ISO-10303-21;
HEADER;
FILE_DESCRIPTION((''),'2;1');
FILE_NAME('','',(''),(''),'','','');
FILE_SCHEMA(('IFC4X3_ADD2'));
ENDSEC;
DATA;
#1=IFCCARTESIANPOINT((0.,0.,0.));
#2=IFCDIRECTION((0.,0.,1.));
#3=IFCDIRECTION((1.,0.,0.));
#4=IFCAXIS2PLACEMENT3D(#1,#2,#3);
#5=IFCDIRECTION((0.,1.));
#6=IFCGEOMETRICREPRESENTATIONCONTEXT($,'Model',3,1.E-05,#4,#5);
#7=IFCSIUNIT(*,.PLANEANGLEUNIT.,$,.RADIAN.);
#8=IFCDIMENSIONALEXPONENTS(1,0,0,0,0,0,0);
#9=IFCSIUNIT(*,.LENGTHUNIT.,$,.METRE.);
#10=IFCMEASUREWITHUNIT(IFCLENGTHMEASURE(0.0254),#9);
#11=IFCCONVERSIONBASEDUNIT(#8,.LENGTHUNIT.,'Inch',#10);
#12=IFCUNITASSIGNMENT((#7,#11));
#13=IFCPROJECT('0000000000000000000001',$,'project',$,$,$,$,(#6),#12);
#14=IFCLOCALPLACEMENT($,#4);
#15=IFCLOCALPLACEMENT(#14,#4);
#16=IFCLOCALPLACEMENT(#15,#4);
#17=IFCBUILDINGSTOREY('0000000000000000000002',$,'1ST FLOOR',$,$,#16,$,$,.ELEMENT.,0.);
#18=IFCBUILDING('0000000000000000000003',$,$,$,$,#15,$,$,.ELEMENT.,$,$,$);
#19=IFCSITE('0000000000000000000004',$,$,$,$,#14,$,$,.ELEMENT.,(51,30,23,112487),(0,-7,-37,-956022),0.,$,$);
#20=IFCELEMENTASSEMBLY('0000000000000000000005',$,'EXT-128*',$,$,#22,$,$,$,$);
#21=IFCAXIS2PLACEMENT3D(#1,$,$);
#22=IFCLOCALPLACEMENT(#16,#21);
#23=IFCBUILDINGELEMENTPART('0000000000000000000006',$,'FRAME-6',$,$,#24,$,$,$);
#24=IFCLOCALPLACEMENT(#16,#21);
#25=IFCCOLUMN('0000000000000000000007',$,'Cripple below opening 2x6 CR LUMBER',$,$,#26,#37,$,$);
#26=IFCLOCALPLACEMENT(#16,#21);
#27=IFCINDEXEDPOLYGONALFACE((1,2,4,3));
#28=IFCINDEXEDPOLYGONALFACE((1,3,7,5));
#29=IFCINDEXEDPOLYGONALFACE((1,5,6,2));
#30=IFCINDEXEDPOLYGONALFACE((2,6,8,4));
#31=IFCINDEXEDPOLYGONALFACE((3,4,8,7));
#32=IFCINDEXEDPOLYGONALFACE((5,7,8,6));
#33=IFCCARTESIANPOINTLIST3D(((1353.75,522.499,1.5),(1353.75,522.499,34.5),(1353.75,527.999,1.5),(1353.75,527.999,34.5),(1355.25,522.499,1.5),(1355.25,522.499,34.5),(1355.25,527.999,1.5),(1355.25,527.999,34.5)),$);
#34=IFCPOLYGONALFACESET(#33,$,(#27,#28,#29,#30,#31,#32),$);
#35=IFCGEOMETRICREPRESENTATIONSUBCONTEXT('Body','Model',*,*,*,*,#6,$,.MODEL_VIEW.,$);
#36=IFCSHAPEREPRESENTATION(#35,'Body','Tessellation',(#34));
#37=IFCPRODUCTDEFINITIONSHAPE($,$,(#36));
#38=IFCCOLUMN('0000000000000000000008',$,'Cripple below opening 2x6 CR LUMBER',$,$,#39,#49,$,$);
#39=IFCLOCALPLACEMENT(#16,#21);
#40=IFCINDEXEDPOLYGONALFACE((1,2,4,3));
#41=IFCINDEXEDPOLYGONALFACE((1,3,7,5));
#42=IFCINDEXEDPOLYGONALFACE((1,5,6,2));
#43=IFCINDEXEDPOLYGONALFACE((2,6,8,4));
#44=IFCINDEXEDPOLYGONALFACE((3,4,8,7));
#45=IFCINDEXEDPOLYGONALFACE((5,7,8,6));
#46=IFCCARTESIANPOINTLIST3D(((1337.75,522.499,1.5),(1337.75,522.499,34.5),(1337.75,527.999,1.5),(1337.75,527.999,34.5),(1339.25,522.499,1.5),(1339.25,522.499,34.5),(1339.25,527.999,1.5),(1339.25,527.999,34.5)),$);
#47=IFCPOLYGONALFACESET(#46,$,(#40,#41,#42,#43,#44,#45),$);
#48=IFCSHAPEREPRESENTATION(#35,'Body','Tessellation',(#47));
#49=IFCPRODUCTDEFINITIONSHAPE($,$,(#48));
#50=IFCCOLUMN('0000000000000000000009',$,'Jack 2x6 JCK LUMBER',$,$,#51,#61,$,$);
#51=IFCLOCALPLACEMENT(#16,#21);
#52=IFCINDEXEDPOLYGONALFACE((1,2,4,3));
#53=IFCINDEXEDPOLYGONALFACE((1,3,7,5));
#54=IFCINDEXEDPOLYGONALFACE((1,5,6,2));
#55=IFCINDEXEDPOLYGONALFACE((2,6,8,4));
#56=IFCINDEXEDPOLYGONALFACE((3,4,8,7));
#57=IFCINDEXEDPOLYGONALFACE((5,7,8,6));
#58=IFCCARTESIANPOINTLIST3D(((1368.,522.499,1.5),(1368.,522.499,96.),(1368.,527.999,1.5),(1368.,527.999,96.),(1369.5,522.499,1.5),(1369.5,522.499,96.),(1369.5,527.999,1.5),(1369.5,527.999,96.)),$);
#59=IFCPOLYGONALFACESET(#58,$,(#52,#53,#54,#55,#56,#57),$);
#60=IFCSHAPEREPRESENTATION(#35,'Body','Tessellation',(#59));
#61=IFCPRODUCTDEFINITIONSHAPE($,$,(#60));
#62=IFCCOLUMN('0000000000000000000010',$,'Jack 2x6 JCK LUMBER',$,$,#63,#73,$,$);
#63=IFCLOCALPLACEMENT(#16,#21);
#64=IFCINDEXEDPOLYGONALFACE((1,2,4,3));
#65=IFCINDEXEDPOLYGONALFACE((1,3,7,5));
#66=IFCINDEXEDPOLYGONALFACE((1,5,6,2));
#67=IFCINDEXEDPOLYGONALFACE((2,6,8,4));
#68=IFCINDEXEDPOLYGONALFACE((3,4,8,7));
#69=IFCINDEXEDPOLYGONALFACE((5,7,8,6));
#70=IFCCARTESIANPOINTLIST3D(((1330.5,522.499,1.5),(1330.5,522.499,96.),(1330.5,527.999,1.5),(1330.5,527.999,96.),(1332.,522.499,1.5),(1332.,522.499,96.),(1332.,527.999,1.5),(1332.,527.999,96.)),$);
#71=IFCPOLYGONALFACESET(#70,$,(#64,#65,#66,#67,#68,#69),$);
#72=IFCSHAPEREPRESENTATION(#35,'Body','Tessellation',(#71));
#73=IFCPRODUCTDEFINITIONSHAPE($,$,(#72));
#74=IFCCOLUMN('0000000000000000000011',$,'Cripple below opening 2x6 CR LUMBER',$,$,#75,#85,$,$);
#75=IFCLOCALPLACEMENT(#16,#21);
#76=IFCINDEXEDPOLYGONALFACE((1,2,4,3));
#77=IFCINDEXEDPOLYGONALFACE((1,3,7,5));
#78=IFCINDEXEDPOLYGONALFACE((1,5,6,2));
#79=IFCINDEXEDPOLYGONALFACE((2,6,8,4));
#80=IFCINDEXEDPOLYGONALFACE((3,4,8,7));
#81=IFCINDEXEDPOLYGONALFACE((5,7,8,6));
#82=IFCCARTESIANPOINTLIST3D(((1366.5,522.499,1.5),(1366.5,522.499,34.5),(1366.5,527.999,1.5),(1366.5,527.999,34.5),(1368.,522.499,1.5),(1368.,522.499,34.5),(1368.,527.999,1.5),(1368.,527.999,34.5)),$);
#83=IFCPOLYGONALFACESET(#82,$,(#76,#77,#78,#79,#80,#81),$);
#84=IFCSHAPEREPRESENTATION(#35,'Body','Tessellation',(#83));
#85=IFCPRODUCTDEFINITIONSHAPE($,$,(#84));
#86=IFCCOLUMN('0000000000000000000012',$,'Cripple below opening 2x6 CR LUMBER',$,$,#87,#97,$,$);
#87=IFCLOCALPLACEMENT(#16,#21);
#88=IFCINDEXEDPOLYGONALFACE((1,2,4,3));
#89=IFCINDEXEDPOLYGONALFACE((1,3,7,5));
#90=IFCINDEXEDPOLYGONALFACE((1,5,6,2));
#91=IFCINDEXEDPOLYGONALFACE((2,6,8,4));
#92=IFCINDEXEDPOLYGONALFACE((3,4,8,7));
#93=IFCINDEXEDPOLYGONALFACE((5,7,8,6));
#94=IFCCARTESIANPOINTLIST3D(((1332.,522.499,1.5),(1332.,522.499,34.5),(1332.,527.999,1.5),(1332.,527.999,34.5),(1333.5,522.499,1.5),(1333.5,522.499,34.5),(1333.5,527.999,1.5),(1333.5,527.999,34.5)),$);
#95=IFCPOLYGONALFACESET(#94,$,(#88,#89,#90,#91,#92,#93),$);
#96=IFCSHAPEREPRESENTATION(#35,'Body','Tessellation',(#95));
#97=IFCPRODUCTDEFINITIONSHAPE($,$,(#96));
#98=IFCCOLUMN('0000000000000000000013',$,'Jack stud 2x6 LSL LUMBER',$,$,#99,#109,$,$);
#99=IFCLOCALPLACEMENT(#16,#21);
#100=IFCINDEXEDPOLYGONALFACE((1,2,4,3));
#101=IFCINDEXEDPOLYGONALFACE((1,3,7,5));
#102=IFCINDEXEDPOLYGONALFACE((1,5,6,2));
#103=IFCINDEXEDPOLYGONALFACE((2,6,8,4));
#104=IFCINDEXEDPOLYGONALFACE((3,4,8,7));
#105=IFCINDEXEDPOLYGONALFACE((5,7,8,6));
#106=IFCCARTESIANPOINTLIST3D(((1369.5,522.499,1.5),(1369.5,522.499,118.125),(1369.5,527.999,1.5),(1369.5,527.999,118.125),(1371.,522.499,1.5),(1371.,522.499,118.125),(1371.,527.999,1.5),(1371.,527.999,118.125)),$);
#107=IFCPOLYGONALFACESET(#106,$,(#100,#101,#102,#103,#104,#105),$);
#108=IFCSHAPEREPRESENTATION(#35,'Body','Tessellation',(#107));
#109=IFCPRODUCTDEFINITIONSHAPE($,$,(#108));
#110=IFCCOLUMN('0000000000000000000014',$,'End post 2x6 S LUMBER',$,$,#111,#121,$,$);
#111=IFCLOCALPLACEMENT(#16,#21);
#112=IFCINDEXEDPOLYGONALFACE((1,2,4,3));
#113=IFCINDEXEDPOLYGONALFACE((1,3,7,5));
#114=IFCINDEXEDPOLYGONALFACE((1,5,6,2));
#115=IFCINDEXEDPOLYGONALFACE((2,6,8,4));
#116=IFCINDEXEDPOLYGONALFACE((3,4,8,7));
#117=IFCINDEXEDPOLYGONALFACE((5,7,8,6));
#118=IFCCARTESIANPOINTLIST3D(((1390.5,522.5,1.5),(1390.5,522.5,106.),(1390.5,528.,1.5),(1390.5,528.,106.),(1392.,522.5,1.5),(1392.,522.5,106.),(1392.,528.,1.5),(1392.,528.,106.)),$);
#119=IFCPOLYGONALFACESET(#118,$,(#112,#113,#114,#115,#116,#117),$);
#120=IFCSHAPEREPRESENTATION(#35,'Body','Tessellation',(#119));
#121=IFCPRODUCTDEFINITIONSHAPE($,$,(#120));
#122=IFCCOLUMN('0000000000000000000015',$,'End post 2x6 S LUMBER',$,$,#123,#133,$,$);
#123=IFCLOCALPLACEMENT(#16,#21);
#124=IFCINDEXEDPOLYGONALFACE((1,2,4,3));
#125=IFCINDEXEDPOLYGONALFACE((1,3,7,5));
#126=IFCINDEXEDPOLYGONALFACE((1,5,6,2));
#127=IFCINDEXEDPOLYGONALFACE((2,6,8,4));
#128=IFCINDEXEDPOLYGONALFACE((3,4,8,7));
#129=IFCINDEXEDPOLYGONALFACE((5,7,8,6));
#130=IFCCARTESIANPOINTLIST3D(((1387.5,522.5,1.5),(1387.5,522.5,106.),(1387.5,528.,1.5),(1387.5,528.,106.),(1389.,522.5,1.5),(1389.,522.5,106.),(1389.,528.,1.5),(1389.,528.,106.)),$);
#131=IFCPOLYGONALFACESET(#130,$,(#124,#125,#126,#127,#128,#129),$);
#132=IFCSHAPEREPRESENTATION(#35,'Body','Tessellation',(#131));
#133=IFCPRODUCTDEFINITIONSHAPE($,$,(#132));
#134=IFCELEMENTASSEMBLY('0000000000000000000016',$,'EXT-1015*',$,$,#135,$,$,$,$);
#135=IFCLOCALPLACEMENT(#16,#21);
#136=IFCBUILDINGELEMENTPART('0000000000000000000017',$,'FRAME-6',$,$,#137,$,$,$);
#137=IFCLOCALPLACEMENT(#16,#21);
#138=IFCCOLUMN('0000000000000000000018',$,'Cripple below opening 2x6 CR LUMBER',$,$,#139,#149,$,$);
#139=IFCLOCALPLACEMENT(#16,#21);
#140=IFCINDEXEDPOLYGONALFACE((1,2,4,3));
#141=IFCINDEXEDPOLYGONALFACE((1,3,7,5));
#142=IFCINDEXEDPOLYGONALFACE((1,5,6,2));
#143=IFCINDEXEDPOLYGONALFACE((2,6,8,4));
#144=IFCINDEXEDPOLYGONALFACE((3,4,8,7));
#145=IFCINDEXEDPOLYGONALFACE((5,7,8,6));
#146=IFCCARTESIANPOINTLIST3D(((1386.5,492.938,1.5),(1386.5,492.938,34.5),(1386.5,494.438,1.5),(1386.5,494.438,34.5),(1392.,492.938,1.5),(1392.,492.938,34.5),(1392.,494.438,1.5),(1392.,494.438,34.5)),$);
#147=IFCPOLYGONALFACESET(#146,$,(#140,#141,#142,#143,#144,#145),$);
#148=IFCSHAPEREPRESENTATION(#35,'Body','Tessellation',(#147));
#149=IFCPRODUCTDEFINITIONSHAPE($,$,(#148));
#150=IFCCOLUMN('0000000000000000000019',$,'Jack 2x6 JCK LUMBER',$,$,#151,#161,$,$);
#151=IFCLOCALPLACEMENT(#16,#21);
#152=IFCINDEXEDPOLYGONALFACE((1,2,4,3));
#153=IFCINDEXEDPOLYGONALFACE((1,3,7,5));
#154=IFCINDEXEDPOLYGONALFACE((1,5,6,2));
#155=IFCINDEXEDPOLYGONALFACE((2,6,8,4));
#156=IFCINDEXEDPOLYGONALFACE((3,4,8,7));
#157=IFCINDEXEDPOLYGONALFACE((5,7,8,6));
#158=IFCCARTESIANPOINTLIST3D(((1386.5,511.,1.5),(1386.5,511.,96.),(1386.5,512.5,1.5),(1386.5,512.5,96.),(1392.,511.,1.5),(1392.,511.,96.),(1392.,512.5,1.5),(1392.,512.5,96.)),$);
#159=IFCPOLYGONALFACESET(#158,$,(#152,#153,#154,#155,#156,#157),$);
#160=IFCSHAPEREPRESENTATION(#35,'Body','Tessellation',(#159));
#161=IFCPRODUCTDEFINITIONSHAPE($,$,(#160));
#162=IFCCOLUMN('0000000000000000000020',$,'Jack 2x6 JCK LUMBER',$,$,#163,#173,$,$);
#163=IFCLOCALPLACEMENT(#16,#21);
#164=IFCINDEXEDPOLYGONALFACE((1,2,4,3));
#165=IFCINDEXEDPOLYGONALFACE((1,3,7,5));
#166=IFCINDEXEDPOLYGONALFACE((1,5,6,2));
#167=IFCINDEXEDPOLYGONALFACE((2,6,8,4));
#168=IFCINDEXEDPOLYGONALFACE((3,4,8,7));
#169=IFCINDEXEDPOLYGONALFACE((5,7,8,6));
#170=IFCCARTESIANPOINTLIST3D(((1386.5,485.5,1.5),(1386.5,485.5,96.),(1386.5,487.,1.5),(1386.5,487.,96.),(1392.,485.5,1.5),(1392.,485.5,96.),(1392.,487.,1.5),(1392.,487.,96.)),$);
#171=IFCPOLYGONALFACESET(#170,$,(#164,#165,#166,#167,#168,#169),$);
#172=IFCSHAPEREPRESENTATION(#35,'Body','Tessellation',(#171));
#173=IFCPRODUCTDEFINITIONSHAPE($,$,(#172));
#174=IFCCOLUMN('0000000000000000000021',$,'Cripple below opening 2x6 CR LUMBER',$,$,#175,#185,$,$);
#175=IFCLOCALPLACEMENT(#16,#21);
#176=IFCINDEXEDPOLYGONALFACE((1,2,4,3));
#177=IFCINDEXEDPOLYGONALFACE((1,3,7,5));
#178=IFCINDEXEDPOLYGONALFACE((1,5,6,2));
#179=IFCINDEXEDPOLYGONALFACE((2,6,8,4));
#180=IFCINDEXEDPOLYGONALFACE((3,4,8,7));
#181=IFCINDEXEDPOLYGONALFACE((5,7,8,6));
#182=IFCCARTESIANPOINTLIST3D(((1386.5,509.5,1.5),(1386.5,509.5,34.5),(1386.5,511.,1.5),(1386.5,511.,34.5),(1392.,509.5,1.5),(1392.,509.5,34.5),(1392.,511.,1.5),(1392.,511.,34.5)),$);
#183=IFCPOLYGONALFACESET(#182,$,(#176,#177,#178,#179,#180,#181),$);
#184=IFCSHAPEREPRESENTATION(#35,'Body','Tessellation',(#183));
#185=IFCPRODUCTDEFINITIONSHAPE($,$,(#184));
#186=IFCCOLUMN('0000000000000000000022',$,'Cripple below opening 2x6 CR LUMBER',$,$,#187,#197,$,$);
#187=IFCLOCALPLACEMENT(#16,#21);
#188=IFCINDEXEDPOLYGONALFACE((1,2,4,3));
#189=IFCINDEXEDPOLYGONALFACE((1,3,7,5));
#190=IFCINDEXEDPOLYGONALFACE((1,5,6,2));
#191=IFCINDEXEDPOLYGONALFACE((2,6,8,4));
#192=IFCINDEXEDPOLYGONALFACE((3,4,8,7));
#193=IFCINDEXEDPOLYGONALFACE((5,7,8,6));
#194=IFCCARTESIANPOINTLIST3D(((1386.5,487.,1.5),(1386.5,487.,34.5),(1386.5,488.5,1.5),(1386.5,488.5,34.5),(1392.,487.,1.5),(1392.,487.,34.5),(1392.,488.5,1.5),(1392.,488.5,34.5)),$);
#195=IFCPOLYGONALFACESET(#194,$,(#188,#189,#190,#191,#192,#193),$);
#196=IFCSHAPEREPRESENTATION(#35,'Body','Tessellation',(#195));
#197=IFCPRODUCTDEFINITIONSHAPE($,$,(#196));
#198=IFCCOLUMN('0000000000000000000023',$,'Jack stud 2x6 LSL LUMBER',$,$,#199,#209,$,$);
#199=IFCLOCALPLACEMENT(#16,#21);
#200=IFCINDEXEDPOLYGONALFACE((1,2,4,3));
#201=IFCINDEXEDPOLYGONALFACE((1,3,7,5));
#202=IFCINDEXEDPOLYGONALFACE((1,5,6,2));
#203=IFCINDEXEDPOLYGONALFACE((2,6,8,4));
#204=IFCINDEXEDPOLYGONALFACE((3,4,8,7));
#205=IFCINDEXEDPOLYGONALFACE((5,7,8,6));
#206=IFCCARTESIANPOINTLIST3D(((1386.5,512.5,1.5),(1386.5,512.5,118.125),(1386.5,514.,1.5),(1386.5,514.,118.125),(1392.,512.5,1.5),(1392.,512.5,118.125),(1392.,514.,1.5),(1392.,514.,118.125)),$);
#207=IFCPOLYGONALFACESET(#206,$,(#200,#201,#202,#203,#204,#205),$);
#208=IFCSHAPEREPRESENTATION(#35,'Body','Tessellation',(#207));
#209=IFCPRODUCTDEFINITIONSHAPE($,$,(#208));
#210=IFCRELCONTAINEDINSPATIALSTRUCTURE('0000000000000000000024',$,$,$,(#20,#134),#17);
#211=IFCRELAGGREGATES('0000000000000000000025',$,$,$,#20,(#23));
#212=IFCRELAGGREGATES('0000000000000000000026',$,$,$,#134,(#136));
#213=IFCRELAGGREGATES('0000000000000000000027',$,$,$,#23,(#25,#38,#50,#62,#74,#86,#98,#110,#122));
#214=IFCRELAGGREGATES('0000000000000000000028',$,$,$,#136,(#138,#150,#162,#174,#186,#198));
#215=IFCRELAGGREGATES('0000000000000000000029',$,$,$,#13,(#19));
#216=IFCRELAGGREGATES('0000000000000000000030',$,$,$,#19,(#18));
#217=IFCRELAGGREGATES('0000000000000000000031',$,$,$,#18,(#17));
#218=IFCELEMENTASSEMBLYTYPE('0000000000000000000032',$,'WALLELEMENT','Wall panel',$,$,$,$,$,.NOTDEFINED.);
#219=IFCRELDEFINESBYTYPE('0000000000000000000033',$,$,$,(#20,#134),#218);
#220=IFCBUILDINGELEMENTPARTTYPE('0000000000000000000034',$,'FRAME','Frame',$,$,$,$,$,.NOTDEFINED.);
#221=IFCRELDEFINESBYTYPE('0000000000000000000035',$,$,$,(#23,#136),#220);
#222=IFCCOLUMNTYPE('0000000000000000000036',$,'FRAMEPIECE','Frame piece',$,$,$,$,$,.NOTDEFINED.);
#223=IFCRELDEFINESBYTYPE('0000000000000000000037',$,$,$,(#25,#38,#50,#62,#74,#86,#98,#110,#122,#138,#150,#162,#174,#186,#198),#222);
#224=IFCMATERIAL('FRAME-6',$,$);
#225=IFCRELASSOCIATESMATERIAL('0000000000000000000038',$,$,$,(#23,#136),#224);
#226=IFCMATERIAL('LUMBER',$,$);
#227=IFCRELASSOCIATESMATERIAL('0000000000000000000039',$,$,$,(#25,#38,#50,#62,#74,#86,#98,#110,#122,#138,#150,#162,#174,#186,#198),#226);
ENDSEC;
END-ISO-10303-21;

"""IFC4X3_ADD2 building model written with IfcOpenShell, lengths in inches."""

from ifc_helpers import new_model, entity, si_unit, converted_unit, direction, frame, origin_with_axes, origin_2d_with_axis, place, context, subcontext, project, spatial, rectangle, extrude, material, type_object, element, aggregate, save


model = new_model("IFC4X3_ADD2")

# Units and contexts
model_context = context("Model", 3, precision=1e-05, world=origin_with_axes(), true_north=direction((0.0, 1.0)))
body_context = subcontext(model_context, "Body", "Model", "MODEL_VIEW")
ifc_project = project(units=[si_unit("PLANEANGLEUNIT", "RADIAN"), converted_unit("LENGTHUNIT", "Inch", entity("IfcLengthMeasure", 0.0254), si_unit("LENGTHUNIT", "METRE"), dimensions=[1, 0, 0, 0, 0, 0, 0])], contexts=[model_context])

# Site, building, storey
site_placement = place(None, origin_with_axes())
site = spatial("IfcSite", under=ifc_project, at=site_placement, CompositionType="ELEMENT", RefLatitude=(51, 30, 23, 112487), RefLongitude=(0, -7, -37, -956022), RefElevation=0.0)
building_placement = place(site_placement, origin_with_axes())
building = spatial("IfcBuilding", under=site, at=building_placement, CompositionType="ELEMENT")
storey_placement = place(building_placement, origin_with_axes())
storey = spatial("IfcBuildingStorey", under=building, at=storey_placement, Name="1ST FLOOR", CompositionType="ELEMENT", Elevation=0.0)

# Element assemblies, building element parts, columns
element_assembly_type_1 = type_object("IfcElementAssemblyType", Name="WALLELEMENT", Description="Wall panel", PredefinedType="NOTDEFINED")
assembly_1_placement = place(storey_placement, origin_with_axes())
assembly_1 = element("IfcElementAssembly", 1, at=assembly_1_placement, inside=storey, type_object=element_assembly_type_1, Name="EXT-128*")
ifc_material_1 = material(Name="FRAME-6")
building_element_part_type = type_object("IfcBuildingElementPartType", Name="FRAME", Description="Frame", PredefinedType="NOTDEFINED")
building_element_part_1_placement = place(storey_placement, origin_with_axes())
building_element_part_1 = element("IfcBuildingElementPart", 2, at=building_element_part_1_placement, type_object=building_element_part_type, material=ifc_material_1, Name="FRAME-6")
aggregate(assembly_1, [building_element_part_1])
ifc_material_2 = material(Name="LUMBER")
column_type = type_object("IfcColumnType", Name="FRAMEPIECE", Description="Frame piece", PredefinedType="NOTDEFINED")
column_1_placement = place(storey_placement, frame((1354.5, 525.249, 34.5), z_axis=(0.0, 0.0, -1.0), x_axis=(1.0, 0.0, 0.0)))
column_1 = element("IfcColumn", 3, at=column_1_placement, type_object=column_type, material=ifc_material_2, Name="Cripple below opening 2x6 CR LUMBER", context=body_context, shape_type="SweptSolid", body=[
    extrude(rectangle(XDim=1.5, YDim=5.5, at=origin_2d_with_axis()), origin_with_axes(), (0.0, 0.0, 1.0), 33.0),
])
column_2_placement = place(storey_placement, frame((1338.5, 525.249, 34.5), z_axis=(0.0, 0.0, -1.0), x_axis=(1.0, 0.0, 0.0)))
column_2 = element("IfcColumn", 4, at=column_2_placement, type_object=column_type, material=ifc_material_2, Name="Cripple below opening 2x6 CR LUMBER", context=body_context, shape_type="SweptSolid", body=[
    extrude(rectangle(XDim=1.5, YDim=5.5, at=origin_2d_with_axis()), origin_with_axes(), (0.0, 0.0, 1.0), 33.0),
])
column_3_placement = place(storey_placement, frame((1368.75, 525.249, 1.5), z_axis=(0.0, 0.0, 1.0), x_axis=(-1.0, 0.0, 0.0)))
column_3 = element("IfcColumn", 5, at=column_3_placement, type_object=column_type, material=ifc_material_2, Name="Jack 2x6 JCK LUMBER", context=body_context, shape_type="SweptSolid", body=[
    extrude(rectangle(XDim=1.5, YDim=5.5, at=origin_2d_with_axis()), origin_with_axes(), (0.0, 0.0, 1.0), 94.5),
])
column_4_placement = place(storey_placement, frame((1331.25, 525.249, 96.0), z_axis=(0.0, 0.0, -1.0), x_axis=(1.0, 0.0, 0.0)))
column_4 = element("IfcColumn", 6, at=column_4_placement, type_object=column_type, material=ifc_material_2, Name="Jack 2x6 JCK LUMBER", context=body_context, shape_type="SweptSolid", body=[
    extrude(rectangle(XDim=1.5, YDim=5.5, at=origin_2d_with_axis()), origin_with_axes(), (0.0, 0.0, 1.0), 94.5),
])
column_5_placement = place(storey_placement, frame((1367.25, 525.249, 1.5), z_axis=(0.0, 0.0, 1.0), x_axis=(-1.0, 0.0, 0.0)))
column_5 = element("IfcColumn", 7, at=column_5_placement, type_object=column_type, material=ifc_material_2, Name="Cripple below opening 2x6 CR LUMBER", context=body_context, shape_type="SweptSolid", body=[
    extrude(rectangle(XDim=1.5, YDim=5.5, at=origin_2d_with_axis()), origin_with_axes(), (0.0, 0.0, 1.0), 33.0),
])
column_6_placement = place(storey_placement, frame((1332.75, 525.249, 34.5), z_axis=(0.0, 0.0, -1.0), x_axis=(1.0, 0.0, 0.0)))
column_6 = element("IfcColumn", 8, at=column_6_placement, type_object=column_type, material=ifc_material_2, Name="Cripple below opening 2x6 CR LUMBER", context=body_context, shape_type="SweptSolid", body=[
    extrude(rectangle(XDim=1.5, YDim=5.5, at=origin_2d_with_axis()), origin_with_axes(), (0.0, 0.0, 1.0), 33.0),
])
column_7_placement = place(storey_placement, frame((1370.25, 525.249, 1.5), z_axis=(0.0, 0.0, 1.0), x_axis=(-1.0, 0.0, 0.0)))
column_7 = element("IfcColumn", 9, at=column_7_placement, type_object=column_type, material=ifc_material_2, Name="Jack stud 2x6 LSL LUMBER", context=body_context, shape_type="SweptSolid", body=[
    extrude(rectangle(XDim=1.5, YDim=5.5, at=origin_2d_with_axis()), origin_with_axes(), (0.0, 0.0, 1.0), 116.625),
])
column_8_placement = place(storey_placement, frame((1391.25, 525.25, 1.5), z_axis=(0.0, 0.0, 1.0), x_axis=(-1.0, 0.0, 0.0)))
column_8 = element("IfcColumn", 10, at=column_8_placement, type_object=column_type, material=ifc_material_2, Name="End post 2x6 S LUMBER", context=body_context, shape_type="SweptSolid", body=[
    extrude(rectangle(XDim=1.5, YDim=5.5, at=origin_2d_with_axis()), origin_with_axes(), (0.0, 0.0, 1.0), 104.5),
])
column_9_placement = place(storey_placement, frame((1388.25, 525.25, 1.5), z_axis=(0.0, 0.0, 1.0), x_axis=(-1.0, 0.0, 0.0)))
column_9 = element("IfcColumn", 11, at=column_9_placement, type_object=column_type, material=ifc_material_2, Name="End post 2x6 S LUMBER", context=body_context, shape_type="SweptSolid", body=[
    extrude(rectangle(XDim=1.5, YDim=5.5, at=origin_2d_with_axis()), origin_with_axes(), (0.0, 0.0, 1.0), 104.5),
])
assembly_2_placement = place(storey_placement, origin_with_axes())
assembly_2 = element("IfcElementAssembly", 12, at=assembly_2_placement, inside=storey, type_object=element_assembly_type_1, Name="EXT-1015*")
building_element_part_2_placement = place(storey_placement, origin_with_axes())
building_element_part_2 = element("IfcBuildingElementPart", 13, at=building_element_part_2_placement, type_object=building_element_part_type, material=ifc_material_1, Name="FRAME-6")
aggregate(assembly_2, [building_element_part_2])
column_10_placement = place(storey_placement, frame((1389.25, 493.688, 34.5), z_axis=(0.0, 0.0, -1.0), x_axis=(0.0, 1.0, 0.0)))
column_10 = element("IfcColumn", 14, at=column_10_placement, type_object=column_type, material=ifc_material_2, Name="Cripple below opening 2x6 CR LUMBER", context=body_context, shape_type="SweptSolid", body=[
    extrude(rectangle(XDim=1.5, YDim=5.5, at=origin_2d_with_axis()), origin_with_axes(), (0.0, 0.0, 1.0), 33.0),
])
column_11_placement = place(storey_placement, frame((1389.25, 511.75, 1.5), z_axis=(0.0, 0.0, 1.0), x_axis=(0.0, -1.0, 0.0)))
column_11 = element("IfcColumn", 15, at=column_11_placement, type_object=column_type, material=ifc_material_2, Name="Jack 2x6 JCK LUMBER", context=body_context, shape_type="SweptSolid", body=[
    extrude(rectangle(XDim=1.5, YDim=5.5, at=origin_2d_with_axis()), origin_with_axes(), (0.0, 0.0, 1.0), 94.5),
])
column_12_placement = place(storey_placement, frame((1389.25, 486.25, 96.0), z_axis=(0.0, 0.0, -1.0), x_axis=(0.0, 1.0, 0.0)))
column_12 = element("IfcColumn", 16, at=column_12_placement, type_object=column_type, material=ifc_material_2, Name="Jack 2x6 JCK LUMBER", context=body_context, shape_type="SweptSolid", body=[
    extrude(rectangle(XDim=1.5, YDim=5.5, at=origin_2d_with_axis()), origin_with_axes(), (0.0, 0.0, 1.0), 94.5),
])
column_13_placement = place(storey_placement, frame((1389.25, 510.25, 1.5), z_axis=(0.0, 0.0, 1.0), x_axis=(0.0, -1.0, 0.0)))
column_13 = element("IfcColumn", 17, at=column_13_placement, type_object=column_type, material=ifc_material_2, Name="Cripple below opening 2x6 CR LUMBER", context=body_context, shape_type="SweptSolid", body=[
    extrude(rectangle(XDim=1.5, YDim=5.5, at=origin_2d_with_axis()), origin_with_axes(), (0.0, 0.0, 1.0), 33.0),
])
column_14_placement = place(storey_placement, frame((1389.25, 487.75, 34.5), z_axis=(0.0, 0.0, -1.0), x_axis=(0.0, 1.0, 0.0)))
column_14 = element("IfcColumn", 18, at=column_14_placement, type_object=column_type, material=ifc_material_2, Name="Cripple below opening 2x6 CR LUMBER", context=body_context, shape_type="SweptSolid", body=[
    extrude(rectangle(XDim=1.5, YDim=5.5, at=origin_2d_with_axis()), origin_with_axes(), (0.0, 0.0, 1.0), 33.0),
])
column_15_placement = place(storey_placement, frame((1389.25, 513.25, 1.5), z_axis=(0.0, 0.0, 1.0), x_axis=(0.0, -1.0, 0.0)))
column_15 = element("IfcColumn", 19, at=column_15_placement, type_object=column_type, material=ifc_material_2, Name="Jack stud 2x6 LSL LUMBER", context=body_context, shape_type="SweptSolid", body=[
    extrude(rectangle(XDim=1.5, YDim=5.5, at=origin_2d_with_axis()), origin_with_axes(), (0.0, 0.0, 1.0), 116.625),
])

aggregate(building_element_part_1, [column_1, column_2, column_3, column_4, column_5, column_6, column_7, column_8, column_9])
aggregate(building_element_part_2, [column_10, column_11, column_12, column_13, column_14, column_15])

save(model, "model.ifc")
